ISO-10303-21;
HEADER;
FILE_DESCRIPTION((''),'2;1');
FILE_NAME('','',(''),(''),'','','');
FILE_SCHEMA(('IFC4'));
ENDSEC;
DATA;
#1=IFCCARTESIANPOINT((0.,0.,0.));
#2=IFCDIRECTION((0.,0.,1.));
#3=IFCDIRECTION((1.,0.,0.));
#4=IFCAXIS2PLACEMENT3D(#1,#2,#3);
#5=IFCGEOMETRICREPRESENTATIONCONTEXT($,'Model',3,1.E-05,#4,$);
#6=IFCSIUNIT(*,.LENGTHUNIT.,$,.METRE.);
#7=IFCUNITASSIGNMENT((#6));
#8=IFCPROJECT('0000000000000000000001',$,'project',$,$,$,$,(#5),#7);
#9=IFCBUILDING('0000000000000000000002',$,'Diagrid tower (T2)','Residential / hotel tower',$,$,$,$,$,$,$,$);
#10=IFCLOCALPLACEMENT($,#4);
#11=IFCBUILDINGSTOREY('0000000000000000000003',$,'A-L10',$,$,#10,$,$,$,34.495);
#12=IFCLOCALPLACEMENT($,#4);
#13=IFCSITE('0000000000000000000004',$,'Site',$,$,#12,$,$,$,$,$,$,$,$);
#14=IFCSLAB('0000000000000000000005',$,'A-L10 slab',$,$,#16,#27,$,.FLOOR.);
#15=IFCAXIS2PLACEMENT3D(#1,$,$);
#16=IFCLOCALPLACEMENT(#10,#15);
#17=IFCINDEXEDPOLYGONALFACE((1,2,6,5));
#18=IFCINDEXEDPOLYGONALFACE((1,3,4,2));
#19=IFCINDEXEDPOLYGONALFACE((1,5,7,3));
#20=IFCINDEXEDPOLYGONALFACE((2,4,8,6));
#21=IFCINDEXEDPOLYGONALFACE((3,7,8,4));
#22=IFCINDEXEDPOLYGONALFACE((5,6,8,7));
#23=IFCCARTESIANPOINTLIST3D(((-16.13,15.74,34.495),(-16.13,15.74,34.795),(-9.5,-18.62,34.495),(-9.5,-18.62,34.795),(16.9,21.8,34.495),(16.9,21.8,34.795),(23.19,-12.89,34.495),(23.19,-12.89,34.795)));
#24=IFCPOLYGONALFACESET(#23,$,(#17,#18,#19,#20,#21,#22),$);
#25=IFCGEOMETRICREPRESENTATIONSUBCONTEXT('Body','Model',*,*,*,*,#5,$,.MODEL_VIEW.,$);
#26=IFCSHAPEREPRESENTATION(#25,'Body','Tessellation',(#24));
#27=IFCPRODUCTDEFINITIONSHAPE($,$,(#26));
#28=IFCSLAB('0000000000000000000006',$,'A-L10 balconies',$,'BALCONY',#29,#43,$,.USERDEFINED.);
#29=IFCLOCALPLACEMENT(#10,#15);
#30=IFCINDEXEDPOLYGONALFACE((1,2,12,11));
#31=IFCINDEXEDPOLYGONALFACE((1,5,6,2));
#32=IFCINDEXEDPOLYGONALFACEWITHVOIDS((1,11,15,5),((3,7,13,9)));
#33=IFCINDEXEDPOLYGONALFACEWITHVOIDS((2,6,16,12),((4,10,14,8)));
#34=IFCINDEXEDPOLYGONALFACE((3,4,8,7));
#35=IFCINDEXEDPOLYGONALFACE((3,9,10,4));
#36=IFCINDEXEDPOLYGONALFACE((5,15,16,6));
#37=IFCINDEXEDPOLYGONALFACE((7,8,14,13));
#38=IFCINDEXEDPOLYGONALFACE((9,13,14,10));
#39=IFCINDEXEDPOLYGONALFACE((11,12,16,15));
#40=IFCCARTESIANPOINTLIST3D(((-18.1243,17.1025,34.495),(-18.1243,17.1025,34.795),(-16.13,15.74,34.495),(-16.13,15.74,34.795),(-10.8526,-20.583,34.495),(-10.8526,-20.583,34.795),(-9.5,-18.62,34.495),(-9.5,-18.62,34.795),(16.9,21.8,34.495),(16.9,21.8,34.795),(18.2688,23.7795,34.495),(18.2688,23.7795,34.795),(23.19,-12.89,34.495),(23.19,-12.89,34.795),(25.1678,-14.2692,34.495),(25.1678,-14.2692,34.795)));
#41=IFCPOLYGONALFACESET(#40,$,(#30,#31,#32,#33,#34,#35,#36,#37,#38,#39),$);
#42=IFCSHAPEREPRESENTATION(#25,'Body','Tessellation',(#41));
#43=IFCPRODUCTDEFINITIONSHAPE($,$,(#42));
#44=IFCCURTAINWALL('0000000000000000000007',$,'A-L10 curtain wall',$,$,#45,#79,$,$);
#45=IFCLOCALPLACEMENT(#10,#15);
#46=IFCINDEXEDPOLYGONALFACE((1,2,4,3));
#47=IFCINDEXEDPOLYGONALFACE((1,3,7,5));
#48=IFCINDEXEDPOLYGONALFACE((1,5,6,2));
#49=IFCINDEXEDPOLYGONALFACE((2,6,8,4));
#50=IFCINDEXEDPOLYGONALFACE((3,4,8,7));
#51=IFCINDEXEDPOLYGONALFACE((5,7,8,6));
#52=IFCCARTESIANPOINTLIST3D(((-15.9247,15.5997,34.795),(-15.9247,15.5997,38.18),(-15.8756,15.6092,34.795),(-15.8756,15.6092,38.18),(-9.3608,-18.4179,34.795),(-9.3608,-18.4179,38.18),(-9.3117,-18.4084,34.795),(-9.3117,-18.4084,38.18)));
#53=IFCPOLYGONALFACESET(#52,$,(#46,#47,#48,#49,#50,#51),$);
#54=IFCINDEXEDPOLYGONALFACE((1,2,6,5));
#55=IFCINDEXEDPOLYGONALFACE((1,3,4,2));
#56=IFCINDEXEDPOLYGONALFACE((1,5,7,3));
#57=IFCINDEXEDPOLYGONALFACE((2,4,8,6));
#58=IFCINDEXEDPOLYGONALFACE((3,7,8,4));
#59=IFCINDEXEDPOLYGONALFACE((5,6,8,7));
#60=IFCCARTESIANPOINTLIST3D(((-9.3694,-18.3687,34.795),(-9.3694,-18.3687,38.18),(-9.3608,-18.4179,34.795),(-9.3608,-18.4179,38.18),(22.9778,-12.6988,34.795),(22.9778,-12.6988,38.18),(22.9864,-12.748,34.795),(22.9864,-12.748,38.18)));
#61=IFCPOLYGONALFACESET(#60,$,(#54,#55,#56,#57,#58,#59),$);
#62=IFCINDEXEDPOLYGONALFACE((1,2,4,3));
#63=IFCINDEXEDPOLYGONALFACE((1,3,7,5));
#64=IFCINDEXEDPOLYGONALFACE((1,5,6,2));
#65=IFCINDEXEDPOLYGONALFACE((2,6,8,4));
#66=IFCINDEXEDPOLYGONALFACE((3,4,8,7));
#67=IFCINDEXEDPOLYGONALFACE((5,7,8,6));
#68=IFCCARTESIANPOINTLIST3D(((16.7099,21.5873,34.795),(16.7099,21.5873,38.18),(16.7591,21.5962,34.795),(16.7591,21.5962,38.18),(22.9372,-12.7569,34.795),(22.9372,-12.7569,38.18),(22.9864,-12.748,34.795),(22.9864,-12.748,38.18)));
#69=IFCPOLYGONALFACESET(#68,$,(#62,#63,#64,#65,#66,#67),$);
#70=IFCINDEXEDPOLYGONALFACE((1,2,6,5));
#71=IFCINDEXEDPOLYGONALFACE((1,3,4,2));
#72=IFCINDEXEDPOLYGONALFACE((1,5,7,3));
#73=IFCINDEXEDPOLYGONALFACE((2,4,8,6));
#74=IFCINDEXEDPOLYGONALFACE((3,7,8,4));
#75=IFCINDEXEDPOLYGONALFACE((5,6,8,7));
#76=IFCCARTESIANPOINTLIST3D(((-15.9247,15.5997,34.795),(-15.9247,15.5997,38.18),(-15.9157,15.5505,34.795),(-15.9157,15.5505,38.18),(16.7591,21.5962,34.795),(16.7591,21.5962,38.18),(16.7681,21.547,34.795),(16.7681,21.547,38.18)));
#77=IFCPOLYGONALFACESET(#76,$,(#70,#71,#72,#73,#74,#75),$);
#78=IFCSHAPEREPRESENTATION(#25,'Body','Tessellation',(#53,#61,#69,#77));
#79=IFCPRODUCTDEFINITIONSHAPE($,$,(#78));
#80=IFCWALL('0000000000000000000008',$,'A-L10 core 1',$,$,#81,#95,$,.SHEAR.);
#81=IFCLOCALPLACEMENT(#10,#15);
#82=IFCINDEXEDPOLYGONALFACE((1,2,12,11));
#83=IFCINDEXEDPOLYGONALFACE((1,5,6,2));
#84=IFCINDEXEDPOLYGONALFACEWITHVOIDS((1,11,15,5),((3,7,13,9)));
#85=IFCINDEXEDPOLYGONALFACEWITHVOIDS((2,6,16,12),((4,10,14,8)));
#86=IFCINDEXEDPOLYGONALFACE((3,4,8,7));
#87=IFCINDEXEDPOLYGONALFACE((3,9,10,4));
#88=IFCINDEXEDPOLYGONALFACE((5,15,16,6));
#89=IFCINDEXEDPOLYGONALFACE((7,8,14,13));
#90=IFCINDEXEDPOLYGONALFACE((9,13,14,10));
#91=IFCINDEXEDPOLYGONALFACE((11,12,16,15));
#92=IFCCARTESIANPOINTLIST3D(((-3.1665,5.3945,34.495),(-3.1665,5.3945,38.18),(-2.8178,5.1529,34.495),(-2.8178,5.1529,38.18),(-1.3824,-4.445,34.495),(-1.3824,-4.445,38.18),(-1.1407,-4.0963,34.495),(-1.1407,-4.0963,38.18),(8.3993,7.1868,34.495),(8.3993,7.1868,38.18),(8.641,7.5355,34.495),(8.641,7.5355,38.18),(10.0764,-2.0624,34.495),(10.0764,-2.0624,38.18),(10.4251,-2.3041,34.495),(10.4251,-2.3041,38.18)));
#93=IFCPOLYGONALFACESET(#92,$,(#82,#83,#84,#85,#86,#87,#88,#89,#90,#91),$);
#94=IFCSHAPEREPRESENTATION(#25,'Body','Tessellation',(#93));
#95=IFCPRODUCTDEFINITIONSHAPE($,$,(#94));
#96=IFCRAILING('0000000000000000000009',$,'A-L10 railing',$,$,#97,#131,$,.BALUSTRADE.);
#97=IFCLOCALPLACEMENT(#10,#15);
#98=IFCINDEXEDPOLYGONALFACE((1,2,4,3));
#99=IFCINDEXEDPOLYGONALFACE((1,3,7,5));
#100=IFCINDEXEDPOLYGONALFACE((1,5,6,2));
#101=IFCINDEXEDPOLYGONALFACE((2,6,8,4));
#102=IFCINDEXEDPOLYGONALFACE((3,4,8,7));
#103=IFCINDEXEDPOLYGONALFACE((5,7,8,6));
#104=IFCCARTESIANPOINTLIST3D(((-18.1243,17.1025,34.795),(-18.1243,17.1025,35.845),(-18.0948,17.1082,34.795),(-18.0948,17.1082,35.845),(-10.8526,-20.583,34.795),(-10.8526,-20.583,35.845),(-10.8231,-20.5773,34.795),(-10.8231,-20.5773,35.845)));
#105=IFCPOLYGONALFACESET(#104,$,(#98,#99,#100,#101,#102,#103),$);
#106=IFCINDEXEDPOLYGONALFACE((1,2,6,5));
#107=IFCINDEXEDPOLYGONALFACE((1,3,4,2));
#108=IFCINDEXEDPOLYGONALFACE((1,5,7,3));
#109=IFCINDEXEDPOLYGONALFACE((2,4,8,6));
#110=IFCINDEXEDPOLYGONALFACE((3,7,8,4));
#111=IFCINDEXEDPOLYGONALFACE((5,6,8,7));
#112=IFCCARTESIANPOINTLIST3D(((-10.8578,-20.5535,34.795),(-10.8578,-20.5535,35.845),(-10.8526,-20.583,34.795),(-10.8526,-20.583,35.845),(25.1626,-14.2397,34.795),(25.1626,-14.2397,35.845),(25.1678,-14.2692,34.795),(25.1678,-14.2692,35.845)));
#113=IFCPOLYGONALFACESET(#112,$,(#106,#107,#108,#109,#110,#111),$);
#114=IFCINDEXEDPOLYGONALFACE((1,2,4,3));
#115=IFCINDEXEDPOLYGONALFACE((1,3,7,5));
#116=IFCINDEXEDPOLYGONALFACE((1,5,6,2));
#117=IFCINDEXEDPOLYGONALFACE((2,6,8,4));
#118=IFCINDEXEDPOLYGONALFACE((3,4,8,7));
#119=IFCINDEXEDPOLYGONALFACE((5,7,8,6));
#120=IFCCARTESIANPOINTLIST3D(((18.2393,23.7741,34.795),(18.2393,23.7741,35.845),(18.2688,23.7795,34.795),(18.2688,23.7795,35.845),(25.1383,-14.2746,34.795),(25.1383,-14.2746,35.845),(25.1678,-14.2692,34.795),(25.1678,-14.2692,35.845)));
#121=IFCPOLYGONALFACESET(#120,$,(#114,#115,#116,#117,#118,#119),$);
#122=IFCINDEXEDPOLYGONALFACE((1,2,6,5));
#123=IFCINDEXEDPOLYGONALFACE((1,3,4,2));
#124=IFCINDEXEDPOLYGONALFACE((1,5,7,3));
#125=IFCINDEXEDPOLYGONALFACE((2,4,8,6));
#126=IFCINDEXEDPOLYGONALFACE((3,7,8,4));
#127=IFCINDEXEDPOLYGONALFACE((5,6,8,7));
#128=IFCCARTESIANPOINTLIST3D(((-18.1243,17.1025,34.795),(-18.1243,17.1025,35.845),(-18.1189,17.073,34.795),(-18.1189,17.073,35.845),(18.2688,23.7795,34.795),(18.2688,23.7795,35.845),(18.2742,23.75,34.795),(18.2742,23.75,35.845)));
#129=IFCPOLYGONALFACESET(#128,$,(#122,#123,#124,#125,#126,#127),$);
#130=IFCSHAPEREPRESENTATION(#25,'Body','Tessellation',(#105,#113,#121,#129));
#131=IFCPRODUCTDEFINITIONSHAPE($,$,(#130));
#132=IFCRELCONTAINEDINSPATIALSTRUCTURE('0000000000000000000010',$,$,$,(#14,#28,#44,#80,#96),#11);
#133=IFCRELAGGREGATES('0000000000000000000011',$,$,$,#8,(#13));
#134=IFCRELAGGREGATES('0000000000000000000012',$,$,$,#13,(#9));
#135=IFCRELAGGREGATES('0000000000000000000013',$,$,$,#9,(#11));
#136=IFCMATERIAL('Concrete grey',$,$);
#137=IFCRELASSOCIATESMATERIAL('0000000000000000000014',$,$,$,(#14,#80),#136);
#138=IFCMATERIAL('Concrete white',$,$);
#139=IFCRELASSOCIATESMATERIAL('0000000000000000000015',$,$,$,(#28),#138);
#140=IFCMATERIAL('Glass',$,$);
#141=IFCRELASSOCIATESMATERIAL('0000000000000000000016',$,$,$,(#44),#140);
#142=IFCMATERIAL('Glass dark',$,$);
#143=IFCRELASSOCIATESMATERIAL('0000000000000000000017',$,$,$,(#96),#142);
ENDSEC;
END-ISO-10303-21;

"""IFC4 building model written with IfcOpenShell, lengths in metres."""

from ifc_helpers import new_model, si_unit, frame, origin_with_axes, place, context, subcontext, project, spatial, polyline, outline, extrude, material, element, save


model = new_model("IFC4")

# Units and contexts
model_context = context("Model", 3, precision=1e-05, world=origin_with_axes())
body_context = subcontext(model_context, "Body", "Model", "MODEL_VIEW")
ifc_project = project(units=[si_unit("LENGTHUNIT", "METRE")], contexts=[model_context])

# Site, building, storey
site_placement = place(None, origin_with_axes())
site = spatial("IfcSite", under=ifc_project, at=site_placement, Name="Site")
building = spatial("IfcBuilding", under=site, Name="Diagrid tower (T2)", Description="Residential / hotel tower")
storey_placement = place(None, origin_with_axes())
storey = spatial("IfcBuildingStorey", under=building, at=storey_placement, Name="A-L10", Elevation=34.495)

# Slabs
ifc_material_1 = material(Name="Concrete grey")
slab_1_placement = place(storey_placement, origin_with_axes())
element("IfcSlab", 1, at=slab_1_placement, inside=storey, material=ifc_material_1, Name="A-L10 slab", PredefinedType="FLOOR", context=body_context, shape_type="SweptSolid", body=[
    extrude(outline(polyline([(-16.13, 15.74), (-9.5, -18.62), (23.19, -12.89), (16.9, 21.8), (-16.13, 15.74)])), frame((0.0, 0.0, 34.495), z_axis=(0.0, 0.0, 1.0), x_axis=(1.0, 0.0, 0.0)), (0.0, 0.0, 1.0), 0.3),
])
ifc_material_2 = material(Name="Concrete white")
slab_2_placement = place(storey_placement, origin_with_axes())
element("IfcSlab", 2, at=slab_2_placement, inside=storey, material=ifc_material_2, Name="A-L10 balconies", ObjectType="BALCONY", PredefinedType="USERDEFINED", context=body_context, shape_type="SweptSolid", body=[
    extrude(outline(polyline([(-18.1243, 17.1025), (-10.8526, -20.583), (25.1678, -14.2692), (18.2688, 23.7795), (-18.1243, 17.1025)]), holes=[polyline([(-16.13, 15.74), (-9.5, -18.62), (23.19, -12.89), (16.9, 21.8), (-16.13, 15.74)])]), frame((0.0, 0.0, 34.495), z_axis=(0.0, 0.0, 1.0), x_axis=(1.0, 0.0, 0.0)), (0.0, 0.0, 1.0), 0.3),
])

# Curtain wall
ifc_material_3 = material(Name="Glass")
curtain_wall_placement = place(storey_placement, origin_with_axes())
element("IfcCurtainWall", 3, at=curtain_wall_placement, inside=storey, material=ifc_material_3, Name="A-L10 curtain wall", context=body_context, shape_type="SweptSolid", body=[
    extrude(outline(polyline([(-15.9247, 15.5997), (-9.3608, -18.4179), (-9.3117, -18.4084), (-15.8756, 15.6092), (-15.9247, 15.5997)])), frame((0.0, 0.0, 34.795), z_axis=(0.0, 0.0, 1.0), x_axis=(1.0, 0.0, 0.0)), (0.0, 0.0, 1.0), 3.385),
    extrude(outline(polyline([(-9.3608, -18.4179), (22.9864, -12.748), (22.9778, -12.6988), (-9.3694, -18.3687), (-9.3608, -18.4179)])), frame((0.0, 0.0, 34.795), z_axis=(0.0, 0.0, 1.0), x_axis=(1.0, 0.0, 0.0)), (0.0, 0.0, 1.0), 3.385),
    extrude(outline(polyline([(22.9864, -12.748), (16.7591, 21.5962), (16.7099, 21.5873), (22.9372, -12.7569), (22.9864, -12.748)])), frame((0.0, 0.0, 34.795), z_axis=(0.0, 0.0, 1.0), x_axis=(1.0, 0.0, 0.0)), (0.0, 0.0, 1.0), 3.385),
    extrude(outline(polyline([(16.7591, 21.5962), (-15.9247, 15.5997), (-15.9157, 15.5505), (16.7681, 21.547), (16.7591, 21.5962)])), frame((0.0, 0.0, 34.795), z_axis=(0.0, 0.0, 1.0), x_axis=(1.0, 0.0, 0.0)), (0.0, 0.0, 1.0), 3.385),
])

# Wall
wall_placement = place(storey_placement, origin_with_axes())
element("IfcWall", 4, at=wall_placement, inside=storey, material=ifc_material_1, Name="A-L10 core 1", PredefinedType="SHEAR", context=body_context, shape_type="SweptSolid", body=[
    extrude(outline(polyline([(10.4251, -2.3041), (8.641, 7.5355), (-3.1665, 5.3945), (-1.3824, -4.445), (10.4251, -2.3041)]), holes=[polyline([(10.0764, -2.0624), (8.3993, 7.1868), (-2.8178, 5.1529), (-1.1407, -4.0963), (10.0764, -2.0624)])]), frame((0.0, 0.0, 34.495), z_axis=(0.0, 0.0, 1.0), x_axis=(1.0, 0.0, 0.0)), (0.0, 0.0, 1.0), 3.685),
])

# Railing
ifc_material_4 = material(Name="Glass dark")
railing_placement = place(storey_placement, origin_with_axes())
element("IfcRailing", 5, at=railing_placement, inside=storey, material=ifc_material_4, Name="A-L10 railing", PredefinedType="BALUSTRADE", context=body_context, shape_type="SweptSolid", body=[
    extrude(outline(polyline([(-18.1243, 17.1025), (-10.8526, -20.583), (-10.8231, -20.5773), (-18.0948, 17.1082), (-18.1243, 17.1025)])), frame((0.0, 0.0, 34.795), z_axis=(0.0, 0.0, 1.0), x_axis=(1.0, 0.0, 0.0)), (0.0, 0.0, 1.0), 1.05),
    extrude(outline(polyline([(-10.8526, -20.583), (25.1678, -14.2692), (25.1626, -14.2397), (-10.8578, -20.5535), (-10.8526, -20.583)])), frame((0.0, 0.0, 34.795), z_axis=(0.0, 0.0, 1.0), x_axis=(1.0, 0.0, 0.0)), (0.0, 0.0, 1.0), 1.05),
    extrude(outline(polyline([(25.1678, -14.2692), (18.2688, 23.7795), (18.2393, 23.7741), (25.1383, -14.2746), (25.1678, -14.2692)])), frame((0.0, 0.0, 34.795), z_axis=(0.0, 0.0, 1.0), x_axis=(1.0, 0.0, 0.0)), (0.0, 0.0, 1.0), 1.05),
    extrude(outline(polyline([(18.2688, 23.7795), (-18.1243, 17.1025), (-18.1189, 17.073), (18.2742, 23.75), (18.2688, 23.7795)])), frame((0.0, 0.0, 34.795), z_axis=(0.0, 0.0, 1.0), x_axis=(1.0, 0.0, 0.0)), (0.0, 0.0, 1.0), 1.05),
])

save(model, "model.ifc")
